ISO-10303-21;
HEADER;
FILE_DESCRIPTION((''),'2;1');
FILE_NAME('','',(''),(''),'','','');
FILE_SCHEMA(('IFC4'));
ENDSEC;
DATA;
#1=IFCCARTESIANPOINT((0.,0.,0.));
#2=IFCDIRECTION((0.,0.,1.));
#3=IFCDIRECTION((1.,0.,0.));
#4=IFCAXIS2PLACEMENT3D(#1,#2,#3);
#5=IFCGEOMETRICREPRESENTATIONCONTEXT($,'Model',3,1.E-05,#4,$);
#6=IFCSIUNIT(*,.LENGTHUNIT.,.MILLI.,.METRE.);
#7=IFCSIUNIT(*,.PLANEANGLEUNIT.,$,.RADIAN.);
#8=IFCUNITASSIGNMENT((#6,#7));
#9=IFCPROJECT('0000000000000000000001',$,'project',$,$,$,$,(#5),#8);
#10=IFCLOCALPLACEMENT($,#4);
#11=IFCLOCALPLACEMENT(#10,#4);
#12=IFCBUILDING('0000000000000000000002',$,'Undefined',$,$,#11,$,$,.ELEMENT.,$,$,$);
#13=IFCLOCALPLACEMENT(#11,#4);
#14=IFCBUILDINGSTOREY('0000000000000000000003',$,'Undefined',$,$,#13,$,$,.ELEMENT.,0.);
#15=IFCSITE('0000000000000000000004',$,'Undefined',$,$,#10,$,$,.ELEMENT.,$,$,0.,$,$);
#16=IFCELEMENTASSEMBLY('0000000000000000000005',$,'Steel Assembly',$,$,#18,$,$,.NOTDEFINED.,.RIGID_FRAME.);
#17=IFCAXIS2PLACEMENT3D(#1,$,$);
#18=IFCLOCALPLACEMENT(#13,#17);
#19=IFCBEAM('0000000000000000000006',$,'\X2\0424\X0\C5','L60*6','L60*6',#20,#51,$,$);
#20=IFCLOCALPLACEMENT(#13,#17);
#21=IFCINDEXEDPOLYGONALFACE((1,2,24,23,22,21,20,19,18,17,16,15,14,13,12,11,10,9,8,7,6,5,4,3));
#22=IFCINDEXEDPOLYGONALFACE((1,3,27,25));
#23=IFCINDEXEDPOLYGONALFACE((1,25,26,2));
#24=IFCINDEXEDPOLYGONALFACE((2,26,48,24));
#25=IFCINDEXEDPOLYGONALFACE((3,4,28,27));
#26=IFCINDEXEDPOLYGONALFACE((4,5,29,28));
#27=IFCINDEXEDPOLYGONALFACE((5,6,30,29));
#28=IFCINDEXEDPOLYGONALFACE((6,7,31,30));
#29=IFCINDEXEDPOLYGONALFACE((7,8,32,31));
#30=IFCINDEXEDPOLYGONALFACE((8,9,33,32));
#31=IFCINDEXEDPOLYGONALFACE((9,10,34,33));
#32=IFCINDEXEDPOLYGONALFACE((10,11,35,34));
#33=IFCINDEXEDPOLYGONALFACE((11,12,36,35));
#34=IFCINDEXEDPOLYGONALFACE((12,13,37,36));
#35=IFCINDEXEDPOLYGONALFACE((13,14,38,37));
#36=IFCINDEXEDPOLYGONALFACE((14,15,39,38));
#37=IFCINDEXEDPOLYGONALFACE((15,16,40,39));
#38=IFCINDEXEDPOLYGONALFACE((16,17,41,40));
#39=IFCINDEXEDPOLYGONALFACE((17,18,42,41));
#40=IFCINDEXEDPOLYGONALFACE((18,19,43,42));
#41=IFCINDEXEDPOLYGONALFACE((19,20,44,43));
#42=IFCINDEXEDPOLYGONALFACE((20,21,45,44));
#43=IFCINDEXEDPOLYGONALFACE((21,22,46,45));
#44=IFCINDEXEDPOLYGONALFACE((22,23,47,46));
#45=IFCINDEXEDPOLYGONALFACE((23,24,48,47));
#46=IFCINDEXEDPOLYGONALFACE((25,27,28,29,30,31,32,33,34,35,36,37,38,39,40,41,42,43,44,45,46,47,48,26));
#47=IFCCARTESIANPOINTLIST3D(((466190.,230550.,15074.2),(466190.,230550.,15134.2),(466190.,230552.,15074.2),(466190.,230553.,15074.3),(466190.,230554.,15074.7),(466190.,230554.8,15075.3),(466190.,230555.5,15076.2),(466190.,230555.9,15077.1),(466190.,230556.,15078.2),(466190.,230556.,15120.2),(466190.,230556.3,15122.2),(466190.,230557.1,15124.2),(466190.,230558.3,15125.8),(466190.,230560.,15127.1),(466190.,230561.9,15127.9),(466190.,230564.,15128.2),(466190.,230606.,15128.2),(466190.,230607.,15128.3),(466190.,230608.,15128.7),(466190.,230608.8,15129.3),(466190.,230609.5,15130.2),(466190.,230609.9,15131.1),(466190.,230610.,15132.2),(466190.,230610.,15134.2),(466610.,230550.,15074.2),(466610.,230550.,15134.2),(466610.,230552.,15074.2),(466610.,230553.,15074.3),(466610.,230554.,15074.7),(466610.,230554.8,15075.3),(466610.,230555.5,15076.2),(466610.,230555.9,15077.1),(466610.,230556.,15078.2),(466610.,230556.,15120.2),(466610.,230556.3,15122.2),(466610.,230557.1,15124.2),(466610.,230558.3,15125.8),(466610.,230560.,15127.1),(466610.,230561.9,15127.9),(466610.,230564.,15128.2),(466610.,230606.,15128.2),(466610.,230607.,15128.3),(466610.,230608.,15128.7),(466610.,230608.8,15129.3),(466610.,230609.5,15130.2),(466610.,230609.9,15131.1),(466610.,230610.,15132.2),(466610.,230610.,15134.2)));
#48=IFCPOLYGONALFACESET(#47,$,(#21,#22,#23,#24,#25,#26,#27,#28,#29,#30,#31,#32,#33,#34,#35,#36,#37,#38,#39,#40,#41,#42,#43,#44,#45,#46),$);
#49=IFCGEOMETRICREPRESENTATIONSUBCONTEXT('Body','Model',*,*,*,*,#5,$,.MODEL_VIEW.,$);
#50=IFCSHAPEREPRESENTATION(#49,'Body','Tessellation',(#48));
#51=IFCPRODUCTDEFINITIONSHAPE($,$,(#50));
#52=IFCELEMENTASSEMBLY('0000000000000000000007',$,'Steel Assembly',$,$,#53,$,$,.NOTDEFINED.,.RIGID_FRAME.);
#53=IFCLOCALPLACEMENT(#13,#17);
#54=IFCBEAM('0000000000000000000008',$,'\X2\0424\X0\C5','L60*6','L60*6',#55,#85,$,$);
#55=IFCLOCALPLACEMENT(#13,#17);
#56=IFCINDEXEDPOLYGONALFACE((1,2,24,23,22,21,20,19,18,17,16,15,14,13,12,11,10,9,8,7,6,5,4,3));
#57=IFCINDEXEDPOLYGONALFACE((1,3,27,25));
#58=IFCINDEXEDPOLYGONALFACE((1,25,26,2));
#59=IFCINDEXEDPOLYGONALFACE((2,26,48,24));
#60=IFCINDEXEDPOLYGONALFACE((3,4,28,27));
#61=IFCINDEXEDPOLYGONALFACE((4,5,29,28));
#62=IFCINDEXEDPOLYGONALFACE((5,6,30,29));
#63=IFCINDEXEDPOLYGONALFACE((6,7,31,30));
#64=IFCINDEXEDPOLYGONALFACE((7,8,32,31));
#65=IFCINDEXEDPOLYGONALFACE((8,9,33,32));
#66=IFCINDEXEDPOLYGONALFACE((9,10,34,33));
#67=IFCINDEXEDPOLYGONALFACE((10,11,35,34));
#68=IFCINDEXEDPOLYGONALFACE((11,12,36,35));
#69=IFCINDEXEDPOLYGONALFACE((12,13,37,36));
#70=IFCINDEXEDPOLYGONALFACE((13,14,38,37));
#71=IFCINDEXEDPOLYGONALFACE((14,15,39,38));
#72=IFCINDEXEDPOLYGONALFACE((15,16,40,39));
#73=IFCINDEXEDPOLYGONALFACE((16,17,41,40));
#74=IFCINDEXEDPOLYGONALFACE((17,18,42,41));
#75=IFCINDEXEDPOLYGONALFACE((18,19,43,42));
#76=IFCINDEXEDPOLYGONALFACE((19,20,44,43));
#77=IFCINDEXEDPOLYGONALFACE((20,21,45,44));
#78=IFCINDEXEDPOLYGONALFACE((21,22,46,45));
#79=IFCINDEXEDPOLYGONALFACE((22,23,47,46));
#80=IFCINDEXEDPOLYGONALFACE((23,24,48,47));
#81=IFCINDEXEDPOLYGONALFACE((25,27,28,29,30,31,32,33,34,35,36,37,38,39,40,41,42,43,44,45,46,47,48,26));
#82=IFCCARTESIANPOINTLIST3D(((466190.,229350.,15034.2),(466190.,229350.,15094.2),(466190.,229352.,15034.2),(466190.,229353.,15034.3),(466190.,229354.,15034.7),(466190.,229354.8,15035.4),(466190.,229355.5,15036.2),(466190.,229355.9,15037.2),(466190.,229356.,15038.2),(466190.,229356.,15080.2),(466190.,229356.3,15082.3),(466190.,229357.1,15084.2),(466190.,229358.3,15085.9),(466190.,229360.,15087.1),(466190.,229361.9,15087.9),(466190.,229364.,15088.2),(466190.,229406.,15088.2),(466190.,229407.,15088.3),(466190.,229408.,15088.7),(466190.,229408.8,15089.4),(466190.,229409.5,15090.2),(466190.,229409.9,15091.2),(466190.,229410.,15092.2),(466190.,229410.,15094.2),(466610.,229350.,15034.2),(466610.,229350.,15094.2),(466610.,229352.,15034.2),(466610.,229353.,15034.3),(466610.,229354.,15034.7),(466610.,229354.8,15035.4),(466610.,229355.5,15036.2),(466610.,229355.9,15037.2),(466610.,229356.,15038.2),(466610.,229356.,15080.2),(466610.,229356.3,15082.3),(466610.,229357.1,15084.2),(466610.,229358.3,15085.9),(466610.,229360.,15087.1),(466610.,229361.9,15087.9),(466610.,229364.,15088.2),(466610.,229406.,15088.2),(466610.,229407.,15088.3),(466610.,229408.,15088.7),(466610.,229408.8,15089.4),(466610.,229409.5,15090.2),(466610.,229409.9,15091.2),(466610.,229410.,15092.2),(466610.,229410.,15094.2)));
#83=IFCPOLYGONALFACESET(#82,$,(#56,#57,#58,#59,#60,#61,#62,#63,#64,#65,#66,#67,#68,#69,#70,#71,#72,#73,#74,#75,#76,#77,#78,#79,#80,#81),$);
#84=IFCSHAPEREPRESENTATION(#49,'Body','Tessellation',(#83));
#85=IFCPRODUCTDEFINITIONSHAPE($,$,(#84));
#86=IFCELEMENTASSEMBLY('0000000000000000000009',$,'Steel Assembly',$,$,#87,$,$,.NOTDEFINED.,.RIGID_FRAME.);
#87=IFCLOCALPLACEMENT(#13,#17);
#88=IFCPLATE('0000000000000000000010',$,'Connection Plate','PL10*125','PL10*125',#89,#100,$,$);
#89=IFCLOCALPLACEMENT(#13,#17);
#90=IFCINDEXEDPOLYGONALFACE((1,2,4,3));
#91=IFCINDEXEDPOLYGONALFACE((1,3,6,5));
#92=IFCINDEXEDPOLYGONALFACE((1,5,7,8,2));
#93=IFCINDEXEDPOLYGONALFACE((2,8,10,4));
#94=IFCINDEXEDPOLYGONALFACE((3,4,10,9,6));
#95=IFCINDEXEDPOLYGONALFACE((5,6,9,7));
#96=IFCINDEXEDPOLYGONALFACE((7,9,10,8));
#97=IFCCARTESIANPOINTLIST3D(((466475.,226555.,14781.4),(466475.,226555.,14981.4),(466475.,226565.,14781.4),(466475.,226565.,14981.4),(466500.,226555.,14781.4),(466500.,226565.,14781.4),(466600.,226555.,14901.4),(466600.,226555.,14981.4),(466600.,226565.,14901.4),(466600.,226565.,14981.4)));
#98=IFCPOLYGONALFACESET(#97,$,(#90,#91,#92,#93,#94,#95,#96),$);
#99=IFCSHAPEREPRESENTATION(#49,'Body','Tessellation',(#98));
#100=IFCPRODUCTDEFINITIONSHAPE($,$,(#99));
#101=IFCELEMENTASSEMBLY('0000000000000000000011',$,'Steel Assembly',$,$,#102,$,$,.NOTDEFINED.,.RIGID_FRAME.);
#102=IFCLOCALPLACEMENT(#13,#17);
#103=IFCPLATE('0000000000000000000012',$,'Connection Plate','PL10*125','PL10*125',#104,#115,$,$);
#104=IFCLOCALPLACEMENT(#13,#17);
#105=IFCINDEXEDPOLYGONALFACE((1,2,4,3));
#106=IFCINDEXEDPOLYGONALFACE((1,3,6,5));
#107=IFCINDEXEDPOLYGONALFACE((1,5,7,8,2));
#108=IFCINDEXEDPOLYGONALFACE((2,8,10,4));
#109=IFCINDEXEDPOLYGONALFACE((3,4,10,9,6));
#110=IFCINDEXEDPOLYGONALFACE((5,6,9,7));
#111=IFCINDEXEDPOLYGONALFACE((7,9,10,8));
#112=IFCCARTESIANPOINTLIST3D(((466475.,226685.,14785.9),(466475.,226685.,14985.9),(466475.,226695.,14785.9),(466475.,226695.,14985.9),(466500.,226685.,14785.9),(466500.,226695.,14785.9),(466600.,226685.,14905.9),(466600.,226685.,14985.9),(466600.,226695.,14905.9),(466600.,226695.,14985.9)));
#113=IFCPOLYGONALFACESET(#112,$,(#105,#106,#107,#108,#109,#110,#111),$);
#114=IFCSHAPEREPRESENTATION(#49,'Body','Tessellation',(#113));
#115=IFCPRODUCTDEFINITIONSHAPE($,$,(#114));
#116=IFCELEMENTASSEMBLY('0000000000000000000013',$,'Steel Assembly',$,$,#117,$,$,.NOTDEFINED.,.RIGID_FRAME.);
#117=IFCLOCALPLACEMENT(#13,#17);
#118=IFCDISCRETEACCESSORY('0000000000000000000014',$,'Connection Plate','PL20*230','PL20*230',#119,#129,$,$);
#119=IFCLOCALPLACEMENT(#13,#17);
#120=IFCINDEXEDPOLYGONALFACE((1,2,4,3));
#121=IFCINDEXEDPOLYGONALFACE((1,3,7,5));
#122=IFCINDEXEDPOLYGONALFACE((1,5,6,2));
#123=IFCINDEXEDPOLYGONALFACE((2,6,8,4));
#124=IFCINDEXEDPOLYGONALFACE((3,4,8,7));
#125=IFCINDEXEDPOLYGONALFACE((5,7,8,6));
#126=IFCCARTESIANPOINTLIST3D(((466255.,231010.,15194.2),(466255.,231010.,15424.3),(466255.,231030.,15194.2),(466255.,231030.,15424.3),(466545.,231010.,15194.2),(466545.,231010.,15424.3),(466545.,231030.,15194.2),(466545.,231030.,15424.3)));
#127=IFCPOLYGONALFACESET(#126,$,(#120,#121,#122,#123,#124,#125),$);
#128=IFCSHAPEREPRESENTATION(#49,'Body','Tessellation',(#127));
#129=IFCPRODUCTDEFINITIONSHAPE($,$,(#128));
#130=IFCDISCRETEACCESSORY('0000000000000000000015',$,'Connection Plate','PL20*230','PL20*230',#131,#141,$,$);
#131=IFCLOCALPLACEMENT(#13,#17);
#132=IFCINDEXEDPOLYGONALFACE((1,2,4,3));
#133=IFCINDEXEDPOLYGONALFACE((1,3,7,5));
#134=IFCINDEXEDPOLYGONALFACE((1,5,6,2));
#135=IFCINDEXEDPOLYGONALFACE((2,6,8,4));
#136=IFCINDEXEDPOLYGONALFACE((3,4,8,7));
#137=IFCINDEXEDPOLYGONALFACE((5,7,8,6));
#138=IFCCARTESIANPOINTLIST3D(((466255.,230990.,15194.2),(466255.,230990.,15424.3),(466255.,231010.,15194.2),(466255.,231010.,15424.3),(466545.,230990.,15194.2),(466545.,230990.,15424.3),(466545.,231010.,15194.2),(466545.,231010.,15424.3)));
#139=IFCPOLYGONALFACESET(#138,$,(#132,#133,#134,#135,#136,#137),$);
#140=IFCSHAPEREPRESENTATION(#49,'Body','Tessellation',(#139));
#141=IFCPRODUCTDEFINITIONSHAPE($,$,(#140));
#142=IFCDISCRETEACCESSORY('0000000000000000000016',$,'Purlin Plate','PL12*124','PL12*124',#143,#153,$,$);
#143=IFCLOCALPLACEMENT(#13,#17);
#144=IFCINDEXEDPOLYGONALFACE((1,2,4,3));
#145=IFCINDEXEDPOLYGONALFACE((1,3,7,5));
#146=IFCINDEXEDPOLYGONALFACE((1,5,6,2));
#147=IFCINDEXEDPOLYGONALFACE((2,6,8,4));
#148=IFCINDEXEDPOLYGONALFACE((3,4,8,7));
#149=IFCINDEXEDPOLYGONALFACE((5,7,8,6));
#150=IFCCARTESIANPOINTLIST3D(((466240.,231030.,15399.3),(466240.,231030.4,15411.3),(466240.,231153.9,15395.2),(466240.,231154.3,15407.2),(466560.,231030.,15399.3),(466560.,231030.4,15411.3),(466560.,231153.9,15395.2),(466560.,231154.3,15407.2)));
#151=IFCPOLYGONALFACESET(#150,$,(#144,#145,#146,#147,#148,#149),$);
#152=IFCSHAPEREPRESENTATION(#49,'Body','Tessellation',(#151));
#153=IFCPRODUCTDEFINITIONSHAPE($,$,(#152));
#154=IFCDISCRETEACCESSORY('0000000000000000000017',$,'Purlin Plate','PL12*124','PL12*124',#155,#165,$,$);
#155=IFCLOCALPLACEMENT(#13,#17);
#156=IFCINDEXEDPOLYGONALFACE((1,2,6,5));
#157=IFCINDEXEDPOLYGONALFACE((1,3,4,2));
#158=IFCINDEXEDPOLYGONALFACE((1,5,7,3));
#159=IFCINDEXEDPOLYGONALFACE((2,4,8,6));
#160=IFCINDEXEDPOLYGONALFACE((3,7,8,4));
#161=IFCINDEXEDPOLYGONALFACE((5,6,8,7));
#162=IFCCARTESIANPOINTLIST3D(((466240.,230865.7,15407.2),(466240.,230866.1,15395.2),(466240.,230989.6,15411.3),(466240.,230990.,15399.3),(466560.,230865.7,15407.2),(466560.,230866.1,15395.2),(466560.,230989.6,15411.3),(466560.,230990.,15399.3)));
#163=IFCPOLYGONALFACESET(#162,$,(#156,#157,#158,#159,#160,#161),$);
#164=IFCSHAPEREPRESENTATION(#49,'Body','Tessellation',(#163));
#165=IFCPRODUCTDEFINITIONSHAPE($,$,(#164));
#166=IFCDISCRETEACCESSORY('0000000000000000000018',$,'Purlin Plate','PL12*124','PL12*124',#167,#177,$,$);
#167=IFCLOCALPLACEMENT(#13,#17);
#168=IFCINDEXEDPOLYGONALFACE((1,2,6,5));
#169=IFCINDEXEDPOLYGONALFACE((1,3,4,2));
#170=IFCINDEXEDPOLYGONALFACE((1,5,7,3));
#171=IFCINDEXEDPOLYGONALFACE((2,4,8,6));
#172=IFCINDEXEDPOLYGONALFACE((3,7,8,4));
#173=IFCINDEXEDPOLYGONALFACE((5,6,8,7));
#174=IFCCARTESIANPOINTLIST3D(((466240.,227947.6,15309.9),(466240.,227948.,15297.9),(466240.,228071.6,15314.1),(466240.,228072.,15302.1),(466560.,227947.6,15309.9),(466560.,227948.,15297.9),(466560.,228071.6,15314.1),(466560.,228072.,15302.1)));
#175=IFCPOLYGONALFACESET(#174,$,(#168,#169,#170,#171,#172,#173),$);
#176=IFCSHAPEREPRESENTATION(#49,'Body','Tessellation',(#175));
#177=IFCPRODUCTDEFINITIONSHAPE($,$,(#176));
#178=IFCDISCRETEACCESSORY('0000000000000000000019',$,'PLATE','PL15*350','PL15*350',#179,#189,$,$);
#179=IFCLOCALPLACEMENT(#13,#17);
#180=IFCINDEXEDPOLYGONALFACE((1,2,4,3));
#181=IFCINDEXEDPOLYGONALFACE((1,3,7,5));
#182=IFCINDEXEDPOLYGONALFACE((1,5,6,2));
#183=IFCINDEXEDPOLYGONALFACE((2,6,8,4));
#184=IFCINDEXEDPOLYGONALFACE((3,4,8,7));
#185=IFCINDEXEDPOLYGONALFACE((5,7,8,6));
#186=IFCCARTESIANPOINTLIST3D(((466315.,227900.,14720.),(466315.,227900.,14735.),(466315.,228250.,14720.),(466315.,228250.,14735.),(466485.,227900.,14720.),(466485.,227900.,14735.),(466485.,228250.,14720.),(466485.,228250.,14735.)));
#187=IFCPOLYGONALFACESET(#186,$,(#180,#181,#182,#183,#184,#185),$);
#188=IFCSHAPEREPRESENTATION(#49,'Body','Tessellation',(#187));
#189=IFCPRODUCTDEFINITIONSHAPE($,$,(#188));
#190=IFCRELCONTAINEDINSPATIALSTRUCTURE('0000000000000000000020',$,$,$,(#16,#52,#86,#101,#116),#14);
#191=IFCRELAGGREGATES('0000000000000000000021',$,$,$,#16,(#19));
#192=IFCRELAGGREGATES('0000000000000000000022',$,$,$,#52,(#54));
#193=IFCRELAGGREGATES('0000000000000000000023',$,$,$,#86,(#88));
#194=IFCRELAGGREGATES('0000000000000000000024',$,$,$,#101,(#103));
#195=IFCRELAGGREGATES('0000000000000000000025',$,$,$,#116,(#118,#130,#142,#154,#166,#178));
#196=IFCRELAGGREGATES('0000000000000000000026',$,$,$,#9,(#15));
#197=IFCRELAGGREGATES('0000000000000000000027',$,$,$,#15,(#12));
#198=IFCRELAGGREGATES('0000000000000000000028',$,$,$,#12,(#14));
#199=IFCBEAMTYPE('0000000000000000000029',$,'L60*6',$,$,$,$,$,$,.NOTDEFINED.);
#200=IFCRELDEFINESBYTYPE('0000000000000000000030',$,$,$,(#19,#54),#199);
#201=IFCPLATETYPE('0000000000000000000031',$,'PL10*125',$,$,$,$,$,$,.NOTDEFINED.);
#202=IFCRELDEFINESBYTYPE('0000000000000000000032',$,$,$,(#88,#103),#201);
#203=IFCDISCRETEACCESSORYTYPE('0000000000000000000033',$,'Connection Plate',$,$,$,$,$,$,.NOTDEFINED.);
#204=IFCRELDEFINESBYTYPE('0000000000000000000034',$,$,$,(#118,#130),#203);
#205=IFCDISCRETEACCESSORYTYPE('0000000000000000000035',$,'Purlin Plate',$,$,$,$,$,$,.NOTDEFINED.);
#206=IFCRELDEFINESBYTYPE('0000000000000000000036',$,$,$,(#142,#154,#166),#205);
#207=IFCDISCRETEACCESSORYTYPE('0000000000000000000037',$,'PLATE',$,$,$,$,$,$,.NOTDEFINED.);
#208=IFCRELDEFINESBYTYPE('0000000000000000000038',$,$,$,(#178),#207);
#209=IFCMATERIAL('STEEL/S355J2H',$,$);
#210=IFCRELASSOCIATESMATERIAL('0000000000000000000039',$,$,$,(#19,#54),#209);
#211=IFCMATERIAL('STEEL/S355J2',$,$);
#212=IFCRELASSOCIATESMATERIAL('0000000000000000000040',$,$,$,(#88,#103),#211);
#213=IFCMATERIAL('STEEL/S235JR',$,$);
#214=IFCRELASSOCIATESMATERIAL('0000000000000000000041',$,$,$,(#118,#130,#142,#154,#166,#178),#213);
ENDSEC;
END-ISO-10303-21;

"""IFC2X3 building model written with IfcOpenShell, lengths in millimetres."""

from ifc_helpers import new_model, si_unit, frame, origin_with_axes, origin_2d_with_axis, place, context, subcontext, project, spatial, polyline, l_section, outline, extrude, material, type_object, element, aggregate, save


model = new_model("IFC2X3")

# Units and contexts
model_context = context("Model", 3, precision=1e-05, world=origin_with_axes())
body_context = subcontext(model_context, "Body", "Model", "MODEL_VIEW")
ifc_project = project(units=[si_unit("LENGTHUNIT", "METRE", prefix="MILLI"), si_unit("PLANEANGLEUNIT", "RADIAN")], contexts=[model_context])

# Site, building, storey
site_placement = place(None, origin_with_axes())
site = spatial("IfcSite", under=ifc_project, at=site_placement, Name="Undefined", CompositionType="ELEMENT", RefElevation=0.0)
building_placement = place(site_placement, origin_with_axes())
building = spatial("IfcBuilding", under=site, at=building_placement, Name="Undefined", CompositionType="ELEMENT")
storey_placement = place(building_placement, origin_with_axes())
storey = spatial("IfcBuildingStorey", under=building, at=storey_placement, Name="Undefined", CompositionType="ELEMENT", Elevation=0.0)

# Element assemblies, beams
ifc_material_1 = material(Name="STEEL/S355J2H")
beam_type_1 = type_object("IfcBeamType", Name="L60*6", PredefinedType="NOTDEFINED")
assembly_1_placement = place(storey_placement, origin_with_axes())
assembly_1 = element("IfcElementAssembly", 1, at=assembly_1_placement, inside=storey, Name="Steel Assembly", AssemblyPlace="NOTDEFINED", PredefinedType="RIGID_FRAME")
beam_1_placement = place(assembly_1_placement, frame((466610.0, 230580.0, 15104.2), z_axis=(0.0, 1.0, 0.0), x_axis=(-1.0, 0.0, 0.0)))
beam_1 = element("IfcBeam", 2, at=beam_1_placement, type_object=beam_type_1, material=ifc_material_1, Name="ФC5", Description="L60*6", ObjectType="L60*6", context=body_context, shape_type="SweptSolid", body=[
    extrude(l_section(Depth=60.0, Width=60.0, Thickness=6.0, FilletRadius=8.0, EdgeRadius=4.0, at=origin_2d_with_axis()), frame((420.0, 0.0, 0.0), z_axis=(-1.0, 0.0, 0.0), x_axis=(0.0, -1.0, 0.0)), (0.0, 0.0, 1.0), 420.0),
])
aggregate(assembly_1, [beam_1])
assembly_2_placement = place(storey_placement, origin_with_axes())
assembly_2 = element("IfcElementAssembly", 3, at=assembly_2_placement, inside=storey, Name="Steel Assembly", AssemblyPlace="NOTDEFINED", PredefinedType="RIGID_FRAME")
beam_2_placement = place(assembly_2_placement, frame((466610.0, 229380.0, 15064.2), z_axis=(0.0, 1.0, 0.0), x_axis=(-1.0, 0.0, 0.0)))
beam_2 = element("IfcBeam", 4, at=beam_2_placement, type_object=beam_type_1, material=ifc_material_1, Name="ФC5", Description="L60*6", ObjectType="L60*6", context=body_context, shape_type="SweptSolid", body=[
    extrude(l_section(Depth=60.0, Width=60.0, Thickness=6.0, FilletRadius=8.0, EdgeRadius=4.0, at=origin_2d_with_axis()), frame((420.0, 0.0, 0.0), z_axis=(-1.0, 0.0, 0.0), x_axis=(0.0, -1.0, 0.0)), (0.0, 0.0, 1.0), 420.0),
])
aggregate(assembly_2, [beam_2])

# Element assemblies, plates
assembly_3_placement = place(storey_placement, origin_with_axes())
assembly_3 = element("IfcElementAssembly", 5, at=assembly_3_placement, inside=storey, Name="Steel Assembly", AssemblyPlace="NOTDEFINED", PredefinedType="RIGID_FRAME")
ifc_material_2 = material(Name="STEEL/S355J2")
plate_type = type_object("IfcPlateType", Name="PL10*125", PredefinedType="NOTDEFINED")
plate_1_placement = place(assembly_3_placement, frame((466600.0, 226560.0, 14981.4), z_axis=(0.0, -1.0, 0.0), x_axis=(-1.0, 0.0, 0.0)))
plate_1 = element("IfcPlate", 6, at=plate_1_placement, type_object=plate_type, material=ifc_material_2, Name="Connection Plate", Description="PL10*125", ObjectType="PL10*125", context=body_context, shape_type="SweptSolid", body=[
    extrude(outline(polyline([(0.0, 0.0), (125.0, 0.0), (125.0, 200.0), (100.0, 200.0), (0.0, 80.0), (0.0, 0.0)])), frame((0.0, 0.0, -5.0), z_axis=(0.0, 0.0, 1.0), x_axis=(1.0, 0.0, 0.0)), (0.0, 0.0, 1.0), 10.0),
])
aggregate(assembly_3, [plate_1])
assembly_4_placement = place(storey_placement, origin_with_axes())
assembly_4 = element("IfcElementAssembly", 7, at=assembly_4_placement, inside=storey, Name="Steel Assembly", AssemblyPlace="NOTDEFINED", PredefinedType="RIGID_FRAME")
plate_2_placement = place(assembly_4_placement, frame((466600.0, 226690.0, 14985.9), z_axis=(0.0, -1.0, 0.0), x_axis=(-1.0, 0.0, 0.0)))
plate_2 = element("IfcPlate", 8, at=plate_2_placement, type_object=plate_type, material=ifc_material_2, Name="Connection Plate", Description="PL10*125", ObjectType="PL10*125", context=body_context, shape_type="SweptSolid", body=[
    extrude(outline(polyline([(0.0, 0.0), (125.0, 0.0), (125.0, 200.0), (100.0, 200.0), (0.0, 80.0), (0.0, 0.0)])), frame((0.0, 0.0, -5.0), z_axis=(0.0, 0.0, 1.0), x_axis=(1.0, 0.0, 0.0)), (0.0, 0.0, 1.0), 10.0),
])
aggregate(assembly_4, [plate_2])

# Element assembly, discrete accessories
assembly_5_placement = place(storey_placement, origin_with_axes())
assembly_5 = element("IfcElementAssembly", 9, at=assembly_5_placement, inside=storey, Name="Steel Assembly", AssemblyPlace="NOTDEFINED", PredefinedType="RIGID_FRAME")
ifc_material_3 = material(Name="STEEL/S235JR")
discrete_accessory_type_1 = type_object("IfcDiscreteAccessoryType", Name="Connection Plate")
discrete_accessory_1_placement = place(assembly_5_placement, frame((466545.0, 231020.0, 15424.3), z_axis=(0.0, -1.0, 0.0), x_axis=(-1.0, 0.0, 0.0)))
discrete_accessory_1 = element("IfcDiscreteAccessory", 10, at=discrete_accessory_1_placement, type_object=discrete_accessory_type_1, material=ifc_material_3, Name="Connection Plate", Description="PL20*230", ObjectType="PL20*230", context=body_context, shape_type="SweptSolid", body=[
    extrude(outline(polyline([(0.0, 0.0), (290.0, 0.0), (290.0, 230.1), (0.0, 230.1), (0.0, 0.0)])), frame((0.0, 0.0, -10.0), z_axis=(0.0, 0.0, 1.0), x_axis=(1.0, 0.0, 0.0)), (0.0, 0.0, 1.0), 20.0),
])
discrete_accessory_2_placement = place(assembly_5_placement, frame((466545.0, 231000.0, 15424.3), z_axis=(0.0, -1.0, 0.0), x_axis=(-1.0, 0.0, 0.0)))
discrete_accessory_2 = element("IfcDiscreteAccessory", 11, at=discrete_accessory_2_placement, type_object=discrete_accessory_type_1, material=ifc_material_3, Name="Connection Plate", Description="PL20*230", ObjectType="PL20*230", context=body_context, shape_type="SweptSolid", body=[
    extrude(outline(polyline([(0.0, 0.0), (290.0, 0.0), (290.0, 230.1), (0.0, 230.1), (0.0, 0.0)])), frame((0.0, 0.0, -10.0), z_axis=(0.0, 0.0, 1.0), x_axis=(1.0, 0.0, 0.0)), (0.0, 0.0, 1.0), 20.0),
])
discrete_accessory_type_2 = type_object("IfcDiscreteAccessoryType", Name="Purlin Plate")
discrete_accessory_3_placement = place(assembly_5_placement, frame((466560.0, 231154.1, 15401.2), z_axis=(0.0, -0.033315, -0.999445), x_axis=(0.0, -0.999445, 0.033315)))
discrete_accessory_3 = element("IfcDiscreteAccessory", 12, at=discrete_accessory_3_placement, type_object=discrete_accessory_type_2, material=ifc_material_3, Name="Purlin Plate", Description="PL12*124", ObjectType="PL12*124", context=body_context, shape_type="SweptSolid", body=[
    extrude(outline(polyline([(0.0, 0.0), (124.0, 0.0), (124.0, 320.0), (0.0, 320.0), (0.0, 0.0)])), frame((0.0, 0.0, -6.0), z_axis=(0.0, 0.0, 1.0), x_axis=(1.0, 0.0, 0.0)), (0.0, 0.0, 1.0), 12.0),
])
discrete_accessory_4_placement = place(assembly_5_placement, frame((466560.0, 230865.9, 15401.2), z_axis=(0.0, -0.033315, 0.999445), x_axis=(0.0, 0.999445, 0.033315)))
discrete_accessory_4 = element("IfcDiscreteAccessory", 13, at=discrete_accessory_4_placement, type_object=discrete_accessory_type_2, material=ifc_material_3, Name="Purlin Plate", Description="PL12*124", ObjectType="PL12*124", context=body_context, shape_type="SweptSolid", body=[
    extrude(outline(polyline([(0.0, 0.0), (124.0, 0.0), (124.0, 320.0), (0.0, 320.0), (0.0, 0.0)])), frame((0.0, 0.0, -6.0), z_axis=(0.0, 0.0, 1.0), x_axis=(1.0, 0.0, 0.0)), (0.0, 0.0, 1.0), 12.0),
])
discrete_accessory_5_placement = place(assembly_5_placement, frame((466560.0, 227947.8, 15303.9), z_axis=(0.0, -0.033315, 0.999445), x_axis=(0.0, 0.999445, 0.033315)))
discrete_accessory_5 = element("IfcDiscreteAccessory", 14, at=discrete_accessory_5_placement, type_object=discrete_accessory_type_2, material=ifc_material_3, Name="Purlin Plate", Description="PL12*124", ObjectType="PL12*124", context=body_context, shape_type="SweptSolid", body=[
    extrude(outline(polyline([(0.0, 0.0), (124.0, 0.0), (124.0, 320.0), (0.0, 320.0), (0.0, 0.0)])), frame((0.0, 0.0, -6.0), z_axis=(0.0, 0.0, 1.0), x_axis=(1.0, 0.0, 0.0)), (0.0, 0.0, 1.0), 12.0),
])
discrete_accessory_type_3 = type_object("IfcDiscreteAccessoryType", Name="PLATE")
discrete_accessory_6_placement = place(assembly_5_placement, frame((466485.0, 228075.0, 14727.5), z_axis=(0.0, 0.0, 1.0), x_axis=(-1.0, 0.0, 0.0)))
discrete_accessory_6 = element("IfcDiscreteAccessory", 15, at=discrete_accessory_6_placement, type_object=discrete_accessory_type_3, material=ifc_material_3, Name="PLATE", Description="PL15*350", ObjectType="PL15*350", context=body_context, shape_type="SweptSolid", body=[
    extrude(outline(polyline([(170.0, -175.0), (0.0, -175.0), (0.0, 175.0), (170.0, 175.0), (170.0, -175.0)])), frame((0.0, 0.0, -7.5), z_axis=(0.0, 0.0, 1.0), x_axis=(1.0, 0.0, 0.0)), (0.0, 0.0, 1.0), 15.0),
])
aggregate(assembly_5, [discrete_accessory_1, discrete_accessory_2, discrete_accessory_3, discrete_accessory_4, discrete_accessory_5, discrete_accessory_6])

save(model, "model.ifc")
